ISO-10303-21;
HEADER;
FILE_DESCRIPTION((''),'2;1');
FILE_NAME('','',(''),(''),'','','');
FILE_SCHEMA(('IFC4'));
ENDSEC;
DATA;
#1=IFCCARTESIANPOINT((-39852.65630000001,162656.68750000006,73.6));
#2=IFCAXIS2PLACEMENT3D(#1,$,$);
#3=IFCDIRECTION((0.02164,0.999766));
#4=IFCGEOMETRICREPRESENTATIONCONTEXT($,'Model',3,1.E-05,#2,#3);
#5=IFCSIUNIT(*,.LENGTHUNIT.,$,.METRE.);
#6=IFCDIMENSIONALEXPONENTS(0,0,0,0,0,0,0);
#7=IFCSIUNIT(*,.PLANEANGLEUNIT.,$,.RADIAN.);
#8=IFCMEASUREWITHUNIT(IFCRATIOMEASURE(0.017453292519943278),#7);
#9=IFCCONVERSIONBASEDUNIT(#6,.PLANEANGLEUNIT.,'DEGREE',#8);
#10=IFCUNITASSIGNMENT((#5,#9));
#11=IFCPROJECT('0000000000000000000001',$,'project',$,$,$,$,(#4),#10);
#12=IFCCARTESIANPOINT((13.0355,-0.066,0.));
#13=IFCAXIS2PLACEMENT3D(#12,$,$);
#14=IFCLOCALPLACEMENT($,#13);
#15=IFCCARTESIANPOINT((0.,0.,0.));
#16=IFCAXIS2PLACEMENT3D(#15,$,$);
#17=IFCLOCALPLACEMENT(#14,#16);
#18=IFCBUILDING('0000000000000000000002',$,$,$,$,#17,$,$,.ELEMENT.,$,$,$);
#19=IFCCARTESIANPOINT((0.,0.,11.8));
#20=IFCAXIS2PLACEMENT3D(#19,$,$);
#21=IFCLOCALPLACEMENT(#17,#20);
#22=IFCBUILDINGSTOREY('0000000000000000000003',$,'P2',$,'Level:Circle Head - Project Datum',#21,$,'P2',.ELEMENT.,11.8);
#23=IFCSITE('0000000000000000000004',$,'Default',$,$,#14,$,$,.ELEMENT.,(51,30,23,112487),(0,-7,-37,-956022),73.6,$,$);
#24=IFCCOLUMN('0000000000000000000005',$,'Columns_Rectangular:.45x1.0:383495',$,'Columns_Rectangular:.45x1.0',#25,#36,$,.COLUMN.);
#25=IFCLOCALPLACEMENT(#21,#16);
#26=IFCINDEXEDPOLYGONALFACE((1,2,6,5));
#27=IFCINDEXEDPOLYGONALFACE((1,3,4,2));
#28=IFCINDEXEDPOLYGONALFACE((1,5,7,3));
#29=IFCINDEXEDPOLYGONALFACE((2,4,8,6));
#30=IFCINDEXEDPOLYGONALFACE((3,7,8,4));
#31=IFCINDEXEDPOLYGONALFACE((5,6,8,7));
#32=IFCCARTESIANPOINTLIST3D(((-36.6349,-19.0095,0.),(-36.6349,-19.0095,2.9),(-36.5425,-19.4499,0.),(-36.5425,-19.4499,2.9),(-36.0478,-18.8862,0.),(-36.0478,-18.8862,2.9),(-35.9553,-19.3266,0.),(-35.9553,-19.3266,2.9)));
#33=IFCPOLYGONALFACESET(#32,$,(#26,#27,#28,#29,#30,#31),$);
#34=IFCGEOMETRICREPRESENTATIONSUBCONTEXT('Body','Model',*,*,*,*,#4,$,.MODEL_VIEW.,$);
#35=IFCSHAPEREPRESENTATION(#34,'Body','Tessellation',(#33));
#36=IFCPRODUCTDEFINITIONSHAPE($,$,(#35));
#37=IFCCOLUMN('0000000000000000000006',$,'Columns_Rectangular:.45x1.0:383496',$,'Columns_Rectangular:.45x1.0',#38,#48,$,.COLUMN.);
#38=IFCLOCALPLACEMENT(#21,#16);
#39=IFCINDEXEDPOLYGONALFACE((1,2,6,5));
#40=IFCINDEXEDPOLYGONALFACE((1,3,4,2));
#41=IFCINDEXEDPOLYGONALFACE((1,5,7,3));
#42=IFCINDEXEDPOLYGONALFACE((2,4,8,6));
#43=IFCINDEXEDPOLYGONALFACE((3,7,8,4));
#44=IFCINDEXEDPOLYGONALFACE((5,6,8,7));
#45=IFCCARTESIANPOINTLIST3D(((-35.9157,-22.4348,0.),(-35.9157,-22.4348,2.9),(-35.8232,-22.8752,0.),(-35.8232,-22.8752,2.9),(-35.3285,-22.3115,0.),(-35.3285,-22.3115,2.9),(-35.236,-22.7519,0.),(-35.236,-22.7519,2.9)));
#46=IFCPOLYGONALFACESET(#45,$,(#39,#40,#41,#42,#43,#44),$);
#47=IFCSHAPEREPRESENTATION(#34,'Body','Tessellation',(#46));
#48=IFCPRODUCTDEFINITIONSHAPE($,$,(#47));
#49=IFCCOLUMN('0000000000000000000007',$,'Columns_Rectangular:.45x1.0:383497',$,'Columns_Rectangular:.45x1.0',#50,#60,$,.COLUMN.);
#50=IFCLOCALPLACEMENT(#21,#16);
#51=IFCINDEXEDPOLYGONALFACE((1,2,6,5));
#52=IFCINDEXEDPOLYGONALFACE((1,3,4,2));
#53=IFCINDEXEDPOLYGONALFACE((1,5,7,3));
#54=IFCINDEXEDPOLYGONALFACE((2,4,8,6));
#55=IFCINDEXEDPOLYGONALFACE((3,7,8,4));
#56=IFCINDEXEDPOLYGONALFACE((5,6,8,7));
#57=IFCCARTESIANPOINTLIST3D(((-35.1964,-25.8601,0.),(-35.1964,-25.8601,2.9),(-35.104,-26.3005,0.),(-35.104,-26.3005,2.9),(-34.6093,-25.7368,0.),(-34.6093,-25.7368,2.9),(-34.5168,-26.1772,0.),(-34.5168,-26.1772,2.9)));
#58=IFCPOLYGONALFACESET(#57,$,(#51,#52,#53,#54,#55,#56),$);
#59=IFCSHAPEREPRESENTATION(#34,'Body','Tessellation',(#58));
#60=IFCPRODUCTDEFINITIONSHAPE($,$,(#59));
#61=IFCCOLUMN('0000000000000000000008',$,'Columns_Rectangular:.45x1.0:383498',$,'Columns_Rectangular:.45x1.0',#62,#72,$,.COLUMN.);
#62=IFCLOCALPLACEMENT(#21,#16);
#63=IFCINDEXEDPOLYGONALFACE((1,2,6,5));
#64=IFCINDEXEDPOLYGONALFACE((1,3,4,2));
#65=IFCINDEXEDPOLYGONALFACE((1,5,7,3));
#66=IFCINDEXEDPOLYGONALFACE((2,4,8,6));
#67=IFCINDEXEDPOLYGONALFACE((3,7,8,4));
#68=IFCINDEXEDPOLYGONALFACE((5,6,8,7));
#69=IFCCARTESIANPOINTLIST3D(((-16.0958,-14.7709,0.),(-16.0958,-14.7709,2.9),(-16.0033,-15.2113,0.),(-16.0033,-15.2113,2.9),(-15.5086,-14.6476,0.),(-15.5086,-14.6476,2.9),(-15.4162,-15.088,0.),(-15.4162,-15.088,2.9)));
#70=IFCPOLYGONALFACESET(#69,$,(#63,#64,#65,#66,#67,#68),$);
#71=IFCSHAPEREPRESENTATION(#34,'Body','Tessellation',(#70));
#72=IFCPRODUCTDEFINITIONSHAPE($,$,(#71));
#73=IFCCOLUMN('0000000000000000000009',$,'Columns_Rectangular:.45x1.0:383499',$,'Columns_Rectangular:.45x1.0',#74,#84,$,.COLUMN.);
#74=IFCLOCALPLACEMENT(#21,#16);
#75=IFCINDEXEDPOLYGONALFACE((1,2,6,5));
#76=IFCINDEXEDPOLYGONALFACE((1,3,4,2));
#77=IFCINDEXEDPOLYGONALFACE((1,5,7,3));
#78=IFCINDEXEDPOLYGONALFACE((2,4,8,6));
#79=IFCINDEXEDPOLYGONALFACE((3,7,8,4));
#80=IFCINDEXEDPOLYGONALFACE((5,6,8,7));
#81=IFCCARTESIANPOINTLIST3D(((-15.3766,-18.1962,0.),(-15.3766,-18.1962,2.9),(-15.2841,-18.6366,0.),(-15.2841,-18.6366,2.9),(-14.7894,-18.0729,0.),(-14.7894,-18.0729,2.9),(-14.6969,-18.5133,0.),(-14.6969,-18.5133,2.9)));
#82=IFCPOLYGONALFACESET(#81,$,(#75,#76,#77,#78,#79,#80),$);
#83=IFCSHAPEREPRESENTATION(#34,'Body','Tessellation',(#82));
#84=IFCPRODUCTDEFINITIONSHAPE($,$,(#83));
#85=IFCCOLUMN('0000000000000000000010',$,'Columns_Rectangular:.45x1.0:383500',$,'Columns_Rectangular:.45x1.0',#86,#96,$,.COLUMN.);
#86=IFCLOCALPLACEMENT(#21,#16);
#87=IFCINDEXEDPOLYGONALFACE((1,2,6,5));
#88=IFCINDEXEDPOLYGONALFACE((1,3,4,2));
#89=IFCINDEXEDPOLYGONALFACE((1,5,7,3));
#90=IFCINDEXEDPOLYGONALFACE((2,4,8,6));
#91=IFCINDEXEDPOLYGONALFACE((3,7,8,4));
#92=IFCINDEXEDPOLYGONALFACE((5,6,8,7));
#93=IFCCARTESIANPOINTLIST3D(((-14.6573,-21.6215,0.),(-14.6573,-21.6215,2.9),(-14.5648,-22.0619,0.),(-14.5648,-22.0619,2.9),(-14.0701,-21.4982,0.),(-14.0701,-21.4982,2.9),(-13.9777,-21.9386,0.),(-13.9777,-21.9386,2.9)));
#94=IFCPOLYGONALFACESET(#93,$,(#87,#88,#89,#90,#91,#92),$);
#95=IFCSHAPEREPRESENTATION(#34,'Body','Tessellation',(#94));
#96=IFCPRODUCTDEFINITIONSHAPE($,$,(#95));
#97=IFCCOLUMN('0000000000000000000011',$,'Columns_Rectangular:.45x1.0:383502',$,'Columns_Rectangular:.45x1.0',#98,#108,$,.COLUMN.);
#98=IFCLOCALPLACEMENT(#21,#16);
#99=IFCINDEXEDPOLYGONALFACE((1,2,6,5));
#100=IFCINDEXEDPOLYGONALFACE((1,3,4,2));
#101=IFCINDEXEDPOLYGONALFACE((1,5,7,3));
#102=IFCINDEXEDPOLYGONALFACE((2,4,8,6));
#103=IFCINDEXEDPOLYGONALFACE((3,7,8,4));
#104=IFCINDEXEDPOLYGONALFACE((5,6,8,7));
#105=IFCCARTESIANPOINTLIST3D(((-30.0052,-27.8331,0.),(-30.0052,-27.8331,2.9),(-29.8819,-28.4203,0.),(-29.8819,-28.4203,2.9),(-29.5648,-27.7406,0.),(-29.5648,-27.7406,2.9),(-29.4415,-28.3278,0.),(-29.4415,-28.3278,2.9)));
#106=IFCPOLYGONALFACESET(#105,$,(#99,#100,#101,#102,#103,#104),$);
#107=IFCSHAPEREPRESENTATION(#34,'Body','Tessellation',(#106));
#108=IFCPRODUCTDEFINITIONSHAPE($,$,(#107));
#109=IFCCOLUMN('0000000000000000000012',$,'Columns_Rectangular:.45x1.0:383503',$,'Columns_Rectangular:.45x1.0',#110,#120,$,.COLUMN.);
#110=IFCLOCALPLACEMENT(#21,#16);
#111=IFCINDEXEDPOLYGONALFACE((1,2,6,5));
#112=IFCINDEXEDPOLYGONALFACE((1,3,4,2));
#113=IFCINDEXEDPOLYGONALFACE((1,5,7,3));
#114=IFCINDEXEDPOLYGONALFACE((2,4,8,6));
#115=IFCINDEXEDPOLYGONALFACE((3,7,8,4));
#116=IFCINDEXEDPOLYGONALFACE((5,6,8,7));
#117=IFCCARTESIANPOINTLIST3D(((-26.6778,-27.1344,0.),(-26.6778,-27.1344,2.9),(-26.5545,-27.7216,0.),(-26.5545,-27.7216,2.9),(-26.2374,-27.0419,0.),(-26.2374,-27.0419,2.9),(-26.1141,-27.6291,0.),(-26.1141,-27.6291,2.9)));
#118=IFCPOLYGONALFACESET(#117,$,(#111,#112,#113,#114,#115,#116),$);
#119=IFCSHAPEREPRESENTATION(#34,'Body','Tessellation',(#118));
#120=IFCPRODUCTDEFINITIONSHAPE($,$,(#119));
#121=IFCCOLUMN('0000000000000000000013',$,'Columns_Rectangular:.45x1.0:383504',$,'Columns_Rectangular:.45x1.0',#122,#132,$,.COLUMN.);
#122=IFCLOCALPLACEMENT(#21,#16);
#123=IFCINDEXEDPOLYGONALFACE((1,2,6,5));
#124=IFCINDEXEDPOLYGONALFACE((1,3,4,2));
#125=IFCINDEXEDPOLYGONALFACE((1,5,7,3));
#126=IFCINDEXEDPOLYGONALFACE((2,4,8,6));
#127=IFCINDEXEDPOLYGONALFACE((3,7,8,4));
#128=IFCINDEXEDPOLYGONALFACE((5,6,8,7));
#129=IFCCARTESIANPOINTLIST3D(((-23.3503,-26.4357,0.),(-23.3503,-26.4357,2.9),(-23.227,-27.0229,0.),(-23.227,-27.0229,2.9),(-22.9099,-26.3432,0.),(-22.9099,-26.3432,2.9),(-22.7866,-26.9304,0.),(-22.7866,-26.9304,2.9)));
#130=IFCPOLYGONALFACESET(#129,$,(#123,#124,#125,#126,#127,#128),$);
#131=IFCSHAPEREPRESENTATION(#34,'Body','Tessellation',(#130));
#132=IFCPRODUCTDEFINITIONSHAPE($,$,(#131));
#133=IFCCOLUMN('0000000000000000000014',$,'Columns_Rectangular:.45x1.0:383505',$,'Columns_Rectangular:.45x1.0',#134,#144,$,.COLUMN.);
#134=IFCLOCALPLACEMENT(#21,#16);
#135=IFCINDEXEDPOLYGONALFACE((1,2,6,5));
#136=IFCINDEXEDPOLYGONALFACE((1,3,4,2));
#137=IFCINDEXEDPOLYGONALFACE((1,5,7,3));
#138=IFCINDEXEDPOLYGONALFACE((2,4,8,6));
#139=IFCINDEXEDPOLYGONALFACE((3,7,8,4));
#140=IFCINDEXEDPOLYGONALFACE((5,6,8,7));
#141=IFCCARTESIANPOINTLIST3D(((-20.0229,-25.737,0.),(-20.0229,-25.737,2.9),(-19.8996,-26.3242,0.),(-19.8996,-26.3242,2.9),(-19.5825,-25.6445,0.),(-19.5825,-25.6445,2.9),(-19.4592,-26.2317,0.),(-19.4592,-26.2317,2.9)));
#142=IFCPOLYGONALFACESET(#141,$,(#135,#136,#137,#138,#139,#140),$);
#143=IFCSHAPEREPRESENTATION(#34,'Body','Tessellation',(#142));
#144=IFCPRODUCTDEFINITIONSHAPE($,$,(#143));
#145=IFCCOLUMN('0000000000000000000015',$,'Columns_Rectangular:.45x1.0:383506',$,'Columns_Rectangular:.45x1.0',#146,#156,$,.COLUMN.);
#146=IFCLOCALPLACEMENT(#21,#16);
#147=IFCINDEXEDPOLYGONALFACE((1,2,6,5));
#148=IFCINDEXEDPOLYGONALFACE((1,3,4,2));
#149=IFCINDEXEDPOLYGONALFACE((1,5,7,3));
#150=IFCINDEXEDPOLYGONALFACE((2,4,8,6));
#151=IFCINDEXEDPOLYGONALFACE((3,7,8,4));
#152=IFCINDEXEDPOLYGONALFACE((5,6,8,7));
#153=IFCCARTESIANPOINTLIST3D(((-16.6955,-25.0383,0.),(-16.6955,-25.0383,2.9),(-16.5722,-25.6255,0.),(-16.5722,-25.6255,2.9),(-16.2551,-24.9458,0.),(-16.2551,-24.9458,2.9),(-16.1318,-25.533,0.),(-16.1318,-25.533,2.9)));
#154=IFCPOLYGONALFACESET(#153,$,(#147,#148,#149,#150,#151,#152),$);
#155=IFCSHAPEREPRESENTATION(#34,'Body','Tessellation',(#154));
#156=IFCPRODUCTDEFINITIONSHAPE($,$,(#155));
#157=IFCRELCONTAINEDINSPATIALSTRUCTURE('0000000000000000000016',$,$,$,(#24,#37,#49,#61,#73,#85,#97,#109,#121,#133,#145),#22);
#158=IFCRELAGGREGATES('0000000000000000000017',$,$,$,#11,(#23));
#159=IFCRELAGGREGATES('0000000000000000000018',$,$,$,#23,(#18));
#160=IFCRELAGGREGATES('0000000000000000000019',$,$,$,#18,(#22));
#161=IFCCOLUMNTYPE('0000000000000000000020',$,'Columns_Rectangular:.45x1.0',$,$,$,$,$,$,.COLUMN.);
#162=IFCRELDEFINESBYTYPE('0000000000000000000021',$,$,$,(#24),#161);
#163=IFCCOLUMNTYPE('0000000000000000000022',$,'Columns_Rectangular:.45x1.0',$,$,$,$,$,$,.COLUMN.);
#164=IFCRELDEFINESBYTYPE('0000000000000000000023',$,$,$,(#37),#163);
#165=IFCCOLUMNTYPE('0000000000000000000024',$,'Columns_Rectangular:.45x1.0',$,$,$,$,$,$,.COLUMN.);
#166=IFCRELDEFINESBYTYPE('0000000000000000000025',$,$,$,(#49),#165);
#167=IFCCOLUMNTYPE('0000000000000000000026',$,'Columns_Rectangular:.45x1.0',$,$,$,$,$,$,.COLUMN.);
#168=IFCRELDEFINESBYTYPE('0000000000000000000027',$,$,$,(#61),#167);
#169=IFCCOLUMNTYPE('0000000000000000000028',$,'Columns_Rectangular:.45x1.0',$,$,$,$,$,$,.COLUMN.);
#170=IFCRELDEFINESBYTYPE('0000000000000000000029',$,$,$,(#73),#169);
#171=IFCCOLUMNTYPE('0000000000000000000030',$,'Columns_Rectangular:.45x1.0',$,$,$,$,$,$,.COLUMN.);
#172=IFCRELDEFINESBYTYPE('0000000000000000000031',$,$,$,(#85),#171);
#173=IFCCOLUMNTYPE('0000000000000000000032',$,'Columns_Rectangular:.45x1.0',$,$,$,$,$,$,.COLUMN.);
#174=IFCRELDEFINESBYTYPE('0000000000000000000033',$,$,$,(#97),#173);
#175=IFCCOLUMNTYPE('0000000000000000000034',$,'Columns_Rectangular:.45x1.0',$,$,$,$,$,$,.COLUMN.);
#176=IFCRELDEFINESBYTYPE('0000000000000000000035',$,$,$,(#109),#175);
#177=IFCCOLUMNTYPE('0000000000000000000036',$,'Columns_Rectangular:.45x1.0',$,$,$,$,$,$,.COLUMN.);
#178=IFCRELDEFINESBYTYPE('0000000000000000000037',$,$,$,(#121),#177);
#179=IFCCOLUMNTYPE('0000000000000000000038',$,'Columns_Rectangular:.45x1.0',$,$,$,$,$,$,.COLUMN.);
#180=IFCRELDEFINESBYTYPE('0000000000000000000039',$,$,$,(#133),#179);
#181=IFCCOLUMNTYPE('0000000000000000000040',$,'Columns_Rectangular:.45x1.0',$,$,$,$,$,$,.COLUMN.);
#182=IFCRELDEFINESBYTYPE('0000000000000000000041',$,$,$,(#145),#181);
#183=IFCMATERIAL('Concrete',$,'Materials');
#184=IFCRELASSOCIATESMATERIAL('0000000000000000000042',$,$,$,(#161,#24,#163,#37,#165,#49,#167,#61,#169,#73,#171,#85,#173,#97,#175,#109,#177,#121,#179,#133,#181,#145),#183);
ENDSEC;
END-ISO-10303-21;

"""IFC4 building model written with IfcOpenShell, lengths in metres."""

from ifc_helpers import new_model, entity, si_unit, converted_unit, direction, frame, origin, place, context, subcontext, project, spatial, indexed_curve, outline, extrude, source, transform, mapped, material, type_object, type_shapes, element, save


model = new_model("IFC4")

# Units and contexts
model_context = context("Model", 3, precision=1e-05, world=frame((-39852.65630000001, 162656.68750000006, 73.6)), true_north=direction((0.02164, 0.999766)))
body_context = subcontext(model_context, "Body", "Model", "MODEL_VIEW")
ifc_project = project(units=[si_unit("LENGTHUNIT", "METRE"), converted_unit("PLANEANGLEUNIT", "DEGREE", entity("IfcRatioMeasure", 0.017453292519943278), si_unit("PLANEANGLEUNIT", "RADIAN"), dimensions=[0, 0, 0, 0, 0, 0, 0])], contexts=[model_context])

# Site, building, storey
site_placement = place(None, frame((13.0355, -0.066, 0.0)))
site = spatial("IfcSite", under=ifc_project, at=site_placement, Name="Default", CompositionType="ELEMENT", RefLatitude=(51, 30, 23, 112487), RefLongitude=(0, -7, -37, -956022), RefElevation=73.6)
building_placement = place(site_placement, origin())
building = spatial("IfcBuilding", under=site, at=building_placement, CompositionType="ELEMENT")
storey_placement = place(building_placement, frame((0.0, 0.0, 11.8)))
storey = spatial("IfcBuildingStorey", under=building, at=storey_placement, Name="P2", ObjectType="Level:Circle Head - Project Datum", LongName="P2", CompositionType="ELEMENT", Elevation=11.8)

# Columns
ifc_material = material(Name="Concrete", Category="Materials")
column_type_1 = type_object("IfcColumnType", Name="Columns_Rectangular:.45x1.0", PredefinedType="COLUMN", material=ifc_material)
shared_shape_1 = source(origin(), body_context, "Body", "SweptSolid", [
    extrude(outline(indexed_curve([(-0.3, -0.225), (0.3, -0.225), (0.3, 0.225), (-0.3, 0.225), (-0.3, -0.225)], self_intersect=False)), frame((-36.2951, -19.168, 11.8), z_axis=(0.0, 0.0, 1.0), x_axis=(-0.978657, -0.2055, 0.0)), (0.0, 0.0, 1.0), 2.9),
])
type_shapes(column_type_1, [shared_shape_1])
column_1_placement = place(storey_placement, frame((0.0, 0.0, -11.8)))
element("IfcColumn", 1, at=column_1_placement, inside=storey, type_object=column_type_1, material=ifc_material, Name="Columns_Rectangular:.45x1.0:383495", ObjectType="Columns_Rectangular:.45x1.0", PredefinedType="COLUMN", context=body_context, shape_type="MappedRepresentation", body=[
    mapped(shared_shape_1, transform((0.0, 0.0, 0.0), scale=1.0)),
])
column_type_2 = type_object("IfcColumnType", Name="Columns_Rectangular:.45x1.0", PredefinedType="COLUMN", material=ifc_material)
shared_shape_2 = source(origin(), body_context, "Body", "SweptSolid", [
    extrude(outline(indexed_curve([(-0.3, -0.225), (0.3, -0.225), (0.3, 0.225), (-0.3, 0.225), (-0.3, -0.225)], self_intersect=False)), frame((-35.5759, -22.5933, 11.8), z_axis=(0.0, 0.0, 1.0), x_axis=(-0.978657, -0.2055, 0.0)), (0.0, 0.0, 1.0), 2.9),
])
type_shapes(column_type_2, [shared_shape_2])
column_2_placement = place(storey_placement, frame((0.0, 0.0, -11.8)))
element("IfcColumn", 2, at=column_2_placement, inside=storey, type_object=column_type_2, material=ifc_material, Name="Columns_Rectangular:.45x1.0:383496", ObjectType="Columns_Rectangular:.45x1.0", PredefinedType="COLUMN", context=body_context, shape_type="MappedRepresentation", body=[
    mapped(shared_shape_2, transform((0.0, 0.0, 0.0), scale=1.0)),
])
column_type_3 = type_object("IfcColumnType", Name="Columns_Rectangular:.45x1.0", PredefinedType="COLUMN", material=ifc_material)
shared_shape_3 = source(origin(), body_context, "Body", "SweptSolid", [
    extrude(outline(indexed_curve([(-0.3, -0.225), (0.3, -0.225), (0.3, 0.225), (-0.3, 0.225), (-0.3, -0.225)], self_intersect=False)), frame((-34.8566, -26.0186, 11.8), z_axis=(0.0, 0.0, 1.0), x_axis=(-0.978657, -0.2055, 0.0)), (0.0, 0.0, 1.0), 2.9),
])
type_shapes(column_type_3, [shared_shape_3])
column_3_placement = place(storey_placement, frame((0.0, 0.0, -11.8)))
element("IfcColumn", 3, at=column_3_placement, inside=storey, type_object=column_type_3, material=ifc_material, Name="Columns_Rectangular:.45x1.0:383497", ObjectType="Columns_Rectangular:.45x1.0", PredefinedType="COLUMN", context=body_context, shape_type="MappedRepresentation", body=[
    mapped(shared_shape_3, transform((0.0, 0.0, 0.0), scale=1.0)),
])
column_type_4 = type_object("IfcColumnType", Name="Columns_Rectangular:.45x1.0", PredefinedType="COLUMN", material=ifc_material)
shared_shape_4 = source(origin(), body_context, "Body", "SweptSolid", [
    extrude(outline(indexed_curve([(-0.3, -0.225), (0.3, -0.225), (0.3, 0.225), (-0.3, 0.225), (-0.3, -0.225)], self_intersect=False)), frame((-15.756, -14.9295, 11.8), z_axis=(0.0, 0.0, 1.0), x_axis=(-0.978657, -0.2055, 0.0)), (0.0, 0.0, 1.0), 2.9),
])
type_shapes(column_type_4, [shared_shape_4])
column_4_placement = place(storey_placement, frame((0.0, 0.0, -11.8)))
element("IfcColumn", 4, at=column_4_placement, inside=storey, type_object=column_type_4, material=ifc_material, Name="Columns_Rectangular:.45x1.0:383498", ObjectType="Columns_Rectangular:.45x1.0", PredefinedType="COLUMN", context=body_context, shape_type="MappedRepresentation", body=[
    mapped(shared_shape_4, transform((0.0, 0.0, 0.0), scale=1.0)),
])
column_type_5 = type_object("IfcColumnType", Name="Columns_Rectangular:.45x1.0", PredefinedType="COLUMN", material=ifc_material)
shared_shape_5 = source(origin(), body_context, "Body", "SweptSolid", [
    extrude(outline(indexed_curve([(-0.3, -0.225), (0.3, -0.225), (0.3, 0.225), (-0.3, 0.225), (-0.3, -0.225)], self_intersect=False)), frame((-15.0367, -18.3548, 11.8), z_axis=(0.0, 0.0, 1.0), x_axis=(-0.978657, -0.2055, 0.0)), (0.0, 0.0, 1.0), 2.9),
])
type_shapes(column_type_5, [shared_shape_5])
column_5_placement = place(storey_placement, frame((0.0, 0.0, -11.8)))
element("IfcColumn", 5, at=column_5_placement, inside=storey, type_object=column_type_5, material=ifc_material, Name="Columns_Rectangular:.45x1.0:383499", ObjectType="Columns_Rectangular:.45x1.0", PredefinedType="COLUMN", context=body_context, shape_type="MappedRepresentation", body=[
    mapped(shared_shape_5, transform((0.0, 0.0, 0.0), scale=1.0)),
])
column_type_6 = type_object("IfcColumnType", Name="Columns_Rectangular:.45x1.0", PredefinedType="COLUMN", material=ifc_material)
shared_shape_6 = source(origin(), body_context, "Body", "SweptSolid", [
    extrude(outline(indexed_curve([(-0.3, -0.225), (0.3, -0.225), (0.3, 0.225), (-0.3, 0.225), (-0.3, -0.225)], self_intersect=False)), frame((-14.3175, -21.7801, 11.8), z_axis=(0.0, 0.0, 1.0), x_axis=(-0.978657, -0.2055, 0.0)), (0.0, 0.0, 1.0), 2.9),
])
type_shapes(column_type_6, [shared_shape_6])
column_6_placement = place(storey_placement, frame((0.0, 0.0, -11.8)))
element("IfcColumn", 6, at=column_6_placement, inside=storey, type_object=column_type_6, material=ifc_material, Name="Columns_Rectangular:.45x1.0:383500", ObjectType="Columns_Rectangular:.45x1.0", PredefinedType="COLUMN", context=body_context, shape_type="MappedRepresentation", body=[
    mapped(shared_shape_6, transform((0.0, 0.0, 0.0), scale=1.0)),
])
column_type_7 = type_object("IfcColumnType", Name="Columns_Rectangular:.45x1.0", PredefinedType="COLUMN", material=ifc_material)
shared_shape_7 = source(origin(), body_context, "Body", "SweptSolid", [
    extrude(outline(indexed_curve([(-0.3, -0.225), (0.3, -0.225), (0.3, 0.225), (-0.3, 0.225), (-0.3, -0.225)], self_intersect=False)), frame((-29.7234, -28.0804, 11.8), z_axis=(0.0, 0.0, 1.0), x_axis=(-0.2055, 0.978657, 0.0)), (0.0, 0.0, 1.0), 2.9),
])
type_shapes(column_type_7, [shared_shape_7])
column_7_placement = place(storey_placement, frame((0.0, 0.0, -11.8)))
element("IfcColumn", 7, at=column_7_placement, inside=storey, type_object=column_type_7, material=ifc_material, Name="Columns_Rectangular:.45x1.0:383502", ObjectType="Columns_Rectangular:.45x1.0", PredefinedType="COLUMN", context=body_context, shape_type="MappedRepresentation", body=[
    mapped(shared_shape_7, transform((0.0, 0.0, 0.0), scale=1.0)),
])
column_type_8 = type_object("IfcColumnType", Name="Columns_Rectangular:.45x1.0", PredefinedType="COLUMN", material=ifc_material)
shared_shape_8 = source(origin(), body_context, "Body", "SweptSolid", [
    extrude(outline(indexed_curve([(-0.3, -0.225), (0.3, -0.225), (0.3, 0.225), (-0.3, 0.225), (-0.3, -0.225)], self_intersect=False)), frame((-26.3959, -27.3817, 11.8), z_axis=(0.0, 0.0, 1.0), x_axis=(-0.2055, 0.978657, 0.0)), (0.0, 0.0, 1.0), 2.9),
])
type_shapes(column_type_8, [shared_shape_8])
column_8_placement = place(storey_placement, frame((0.0, 0.0, -11.8)))
element("IfcColumn", 8, at=column_8_placement, inside=storey, type_object=column_type_8, material=ifc_material, Name="Columns_Rectangular:.45x1.0:383503", ObjectType="Columns_Rectangular:.45x1.0", PredefinedType="COLUMN", context=body_context, shape_type="MappedRepresentation", body=[
    mapped(shared_shape_8, transform((0.0, 0.0, 0.0), scale=1.0)),
])
column_type_9 = type_object("IfcColumnType", Name="Columns_Rectangular:.45x1.0", PredefinedType="COLUMN", material=ifc_material)
shared_shape_9 = source(origin(), body_context, "Body", "SweptSolid", [
    extrude(outline(indexed_curve([(-0.3, -0.225), (0.3, -0.225), (0.3, 0.225), (-0.3, 0.225), (-0.3, -0.225)], self_intersect=False)), frame((-23.0685, -26.6831, 11.8), z_axis=(0.0, 0.0, 1.0), x_axis=(-0.2055, 0.978657, 0.0)), (0.0, 0.0, 1.0), 2.9),
])
type_shapes(column_type_9, [shared_shape_9])
column_9_placement = place(storey_placement, frame((0.0, 0.0, -11.8)))
element("IfcColumn", 9, at=column_9_placement, inside=storey, type_object=column_type_9, material=ifc_material, Name="Columns_Rectangular:.45x1.0:383504", ObjectType="Columns_Rectangular:.45x1.0", PredefinedType="COLUMN", context=body_context, shape_type="MappedRepresentation", body=[
    mapped(shared_shape_9, transform((0.0, 0.0, 0.0), scale=1.0)),
])
column_type_10 = type_object("IfcColumnType", Name="Columns_Rectangular:.45x1.0", PredefinedType="COLUMN", material=ifc_material)
shared_shape_10 = source(origin(), body_context, "Body", "SweptSolid", [
    extrude(outline(indexed_curve([(-0.3, -0.225), (0.3, -0.225), (0.3, 0.225), (-0.3, 0.225), (-0.3, -0.225)], self_intersect=False)), frame((-19.741, -25.9844, 11.8), z_axis=(0.0, 0.0, 1.0), x_axis=(-0.2055, 0.978657, 0.0)), (0.0, 0.0, 1.0), 2.9),
])
type_shapes(column_type_10, [shared_shape_10])
column_10_placement = place(storey_placement, frame((0.0, 0.0, -11.8)))
element("IfcColumn", 10, at=column_10_placement, inside=storey, type_object=column_type_10, material=ifc_material, Name="Columns_Rectangular:.45x1.0:383505", ObjectType="Columns_Rectangular:.45x1.0", PredefinedType="COLUMN", context=body_context, shape_type="MappedRepresentation", body=[
    mapped(shared_shape_10, transform((0.0, 0.0, 0.0), scale=1.0)),
])
column_type_11 = type_object("IfcColumnType", Name="Columns_Rectangular:.45x1.0", PredefinedType="COLUMN", material=ifc_material)
shared_shape_11 = source(origin(), body_context, "Body", "SweptSolid", [
    extrude(outline(indexed_curve([(-0.3, -0.225), (0.3, -0.225), (0.3, 0.225), (-0.3, 0.225), (-0.3, -0.225)], self_intersect=False)), frame((-16.4136, -25.2857, 11.8), z_axis=(0.0, 0.0, 1.0), x_axis=(-0.2055, 0.978657, 0.0)), (0.0, 0.0, 1.0), 2.9),
])
type_shapes(column_type_11, [shared_shape_11])
column_11_placement = place(storey_placement, frame((0.0, 0.0, -11.8)))
element("IfcColumn", 11, at=column_11_placement, inside=storey, type_object=column_type_11, material=ifc_material, Name="Columns_Rectangular:.45x1.0:383506", ObjectType="Columns_Rectangular:.45x1.0", PredefinedType="COLUMN", context=body_context, shape_type="MappedRepresentation", body=[
    mapped(shared_shape_11, transform((0.0, 0.0, 0.0), scale=1.0)),
])

save(model, "model.ifc")
